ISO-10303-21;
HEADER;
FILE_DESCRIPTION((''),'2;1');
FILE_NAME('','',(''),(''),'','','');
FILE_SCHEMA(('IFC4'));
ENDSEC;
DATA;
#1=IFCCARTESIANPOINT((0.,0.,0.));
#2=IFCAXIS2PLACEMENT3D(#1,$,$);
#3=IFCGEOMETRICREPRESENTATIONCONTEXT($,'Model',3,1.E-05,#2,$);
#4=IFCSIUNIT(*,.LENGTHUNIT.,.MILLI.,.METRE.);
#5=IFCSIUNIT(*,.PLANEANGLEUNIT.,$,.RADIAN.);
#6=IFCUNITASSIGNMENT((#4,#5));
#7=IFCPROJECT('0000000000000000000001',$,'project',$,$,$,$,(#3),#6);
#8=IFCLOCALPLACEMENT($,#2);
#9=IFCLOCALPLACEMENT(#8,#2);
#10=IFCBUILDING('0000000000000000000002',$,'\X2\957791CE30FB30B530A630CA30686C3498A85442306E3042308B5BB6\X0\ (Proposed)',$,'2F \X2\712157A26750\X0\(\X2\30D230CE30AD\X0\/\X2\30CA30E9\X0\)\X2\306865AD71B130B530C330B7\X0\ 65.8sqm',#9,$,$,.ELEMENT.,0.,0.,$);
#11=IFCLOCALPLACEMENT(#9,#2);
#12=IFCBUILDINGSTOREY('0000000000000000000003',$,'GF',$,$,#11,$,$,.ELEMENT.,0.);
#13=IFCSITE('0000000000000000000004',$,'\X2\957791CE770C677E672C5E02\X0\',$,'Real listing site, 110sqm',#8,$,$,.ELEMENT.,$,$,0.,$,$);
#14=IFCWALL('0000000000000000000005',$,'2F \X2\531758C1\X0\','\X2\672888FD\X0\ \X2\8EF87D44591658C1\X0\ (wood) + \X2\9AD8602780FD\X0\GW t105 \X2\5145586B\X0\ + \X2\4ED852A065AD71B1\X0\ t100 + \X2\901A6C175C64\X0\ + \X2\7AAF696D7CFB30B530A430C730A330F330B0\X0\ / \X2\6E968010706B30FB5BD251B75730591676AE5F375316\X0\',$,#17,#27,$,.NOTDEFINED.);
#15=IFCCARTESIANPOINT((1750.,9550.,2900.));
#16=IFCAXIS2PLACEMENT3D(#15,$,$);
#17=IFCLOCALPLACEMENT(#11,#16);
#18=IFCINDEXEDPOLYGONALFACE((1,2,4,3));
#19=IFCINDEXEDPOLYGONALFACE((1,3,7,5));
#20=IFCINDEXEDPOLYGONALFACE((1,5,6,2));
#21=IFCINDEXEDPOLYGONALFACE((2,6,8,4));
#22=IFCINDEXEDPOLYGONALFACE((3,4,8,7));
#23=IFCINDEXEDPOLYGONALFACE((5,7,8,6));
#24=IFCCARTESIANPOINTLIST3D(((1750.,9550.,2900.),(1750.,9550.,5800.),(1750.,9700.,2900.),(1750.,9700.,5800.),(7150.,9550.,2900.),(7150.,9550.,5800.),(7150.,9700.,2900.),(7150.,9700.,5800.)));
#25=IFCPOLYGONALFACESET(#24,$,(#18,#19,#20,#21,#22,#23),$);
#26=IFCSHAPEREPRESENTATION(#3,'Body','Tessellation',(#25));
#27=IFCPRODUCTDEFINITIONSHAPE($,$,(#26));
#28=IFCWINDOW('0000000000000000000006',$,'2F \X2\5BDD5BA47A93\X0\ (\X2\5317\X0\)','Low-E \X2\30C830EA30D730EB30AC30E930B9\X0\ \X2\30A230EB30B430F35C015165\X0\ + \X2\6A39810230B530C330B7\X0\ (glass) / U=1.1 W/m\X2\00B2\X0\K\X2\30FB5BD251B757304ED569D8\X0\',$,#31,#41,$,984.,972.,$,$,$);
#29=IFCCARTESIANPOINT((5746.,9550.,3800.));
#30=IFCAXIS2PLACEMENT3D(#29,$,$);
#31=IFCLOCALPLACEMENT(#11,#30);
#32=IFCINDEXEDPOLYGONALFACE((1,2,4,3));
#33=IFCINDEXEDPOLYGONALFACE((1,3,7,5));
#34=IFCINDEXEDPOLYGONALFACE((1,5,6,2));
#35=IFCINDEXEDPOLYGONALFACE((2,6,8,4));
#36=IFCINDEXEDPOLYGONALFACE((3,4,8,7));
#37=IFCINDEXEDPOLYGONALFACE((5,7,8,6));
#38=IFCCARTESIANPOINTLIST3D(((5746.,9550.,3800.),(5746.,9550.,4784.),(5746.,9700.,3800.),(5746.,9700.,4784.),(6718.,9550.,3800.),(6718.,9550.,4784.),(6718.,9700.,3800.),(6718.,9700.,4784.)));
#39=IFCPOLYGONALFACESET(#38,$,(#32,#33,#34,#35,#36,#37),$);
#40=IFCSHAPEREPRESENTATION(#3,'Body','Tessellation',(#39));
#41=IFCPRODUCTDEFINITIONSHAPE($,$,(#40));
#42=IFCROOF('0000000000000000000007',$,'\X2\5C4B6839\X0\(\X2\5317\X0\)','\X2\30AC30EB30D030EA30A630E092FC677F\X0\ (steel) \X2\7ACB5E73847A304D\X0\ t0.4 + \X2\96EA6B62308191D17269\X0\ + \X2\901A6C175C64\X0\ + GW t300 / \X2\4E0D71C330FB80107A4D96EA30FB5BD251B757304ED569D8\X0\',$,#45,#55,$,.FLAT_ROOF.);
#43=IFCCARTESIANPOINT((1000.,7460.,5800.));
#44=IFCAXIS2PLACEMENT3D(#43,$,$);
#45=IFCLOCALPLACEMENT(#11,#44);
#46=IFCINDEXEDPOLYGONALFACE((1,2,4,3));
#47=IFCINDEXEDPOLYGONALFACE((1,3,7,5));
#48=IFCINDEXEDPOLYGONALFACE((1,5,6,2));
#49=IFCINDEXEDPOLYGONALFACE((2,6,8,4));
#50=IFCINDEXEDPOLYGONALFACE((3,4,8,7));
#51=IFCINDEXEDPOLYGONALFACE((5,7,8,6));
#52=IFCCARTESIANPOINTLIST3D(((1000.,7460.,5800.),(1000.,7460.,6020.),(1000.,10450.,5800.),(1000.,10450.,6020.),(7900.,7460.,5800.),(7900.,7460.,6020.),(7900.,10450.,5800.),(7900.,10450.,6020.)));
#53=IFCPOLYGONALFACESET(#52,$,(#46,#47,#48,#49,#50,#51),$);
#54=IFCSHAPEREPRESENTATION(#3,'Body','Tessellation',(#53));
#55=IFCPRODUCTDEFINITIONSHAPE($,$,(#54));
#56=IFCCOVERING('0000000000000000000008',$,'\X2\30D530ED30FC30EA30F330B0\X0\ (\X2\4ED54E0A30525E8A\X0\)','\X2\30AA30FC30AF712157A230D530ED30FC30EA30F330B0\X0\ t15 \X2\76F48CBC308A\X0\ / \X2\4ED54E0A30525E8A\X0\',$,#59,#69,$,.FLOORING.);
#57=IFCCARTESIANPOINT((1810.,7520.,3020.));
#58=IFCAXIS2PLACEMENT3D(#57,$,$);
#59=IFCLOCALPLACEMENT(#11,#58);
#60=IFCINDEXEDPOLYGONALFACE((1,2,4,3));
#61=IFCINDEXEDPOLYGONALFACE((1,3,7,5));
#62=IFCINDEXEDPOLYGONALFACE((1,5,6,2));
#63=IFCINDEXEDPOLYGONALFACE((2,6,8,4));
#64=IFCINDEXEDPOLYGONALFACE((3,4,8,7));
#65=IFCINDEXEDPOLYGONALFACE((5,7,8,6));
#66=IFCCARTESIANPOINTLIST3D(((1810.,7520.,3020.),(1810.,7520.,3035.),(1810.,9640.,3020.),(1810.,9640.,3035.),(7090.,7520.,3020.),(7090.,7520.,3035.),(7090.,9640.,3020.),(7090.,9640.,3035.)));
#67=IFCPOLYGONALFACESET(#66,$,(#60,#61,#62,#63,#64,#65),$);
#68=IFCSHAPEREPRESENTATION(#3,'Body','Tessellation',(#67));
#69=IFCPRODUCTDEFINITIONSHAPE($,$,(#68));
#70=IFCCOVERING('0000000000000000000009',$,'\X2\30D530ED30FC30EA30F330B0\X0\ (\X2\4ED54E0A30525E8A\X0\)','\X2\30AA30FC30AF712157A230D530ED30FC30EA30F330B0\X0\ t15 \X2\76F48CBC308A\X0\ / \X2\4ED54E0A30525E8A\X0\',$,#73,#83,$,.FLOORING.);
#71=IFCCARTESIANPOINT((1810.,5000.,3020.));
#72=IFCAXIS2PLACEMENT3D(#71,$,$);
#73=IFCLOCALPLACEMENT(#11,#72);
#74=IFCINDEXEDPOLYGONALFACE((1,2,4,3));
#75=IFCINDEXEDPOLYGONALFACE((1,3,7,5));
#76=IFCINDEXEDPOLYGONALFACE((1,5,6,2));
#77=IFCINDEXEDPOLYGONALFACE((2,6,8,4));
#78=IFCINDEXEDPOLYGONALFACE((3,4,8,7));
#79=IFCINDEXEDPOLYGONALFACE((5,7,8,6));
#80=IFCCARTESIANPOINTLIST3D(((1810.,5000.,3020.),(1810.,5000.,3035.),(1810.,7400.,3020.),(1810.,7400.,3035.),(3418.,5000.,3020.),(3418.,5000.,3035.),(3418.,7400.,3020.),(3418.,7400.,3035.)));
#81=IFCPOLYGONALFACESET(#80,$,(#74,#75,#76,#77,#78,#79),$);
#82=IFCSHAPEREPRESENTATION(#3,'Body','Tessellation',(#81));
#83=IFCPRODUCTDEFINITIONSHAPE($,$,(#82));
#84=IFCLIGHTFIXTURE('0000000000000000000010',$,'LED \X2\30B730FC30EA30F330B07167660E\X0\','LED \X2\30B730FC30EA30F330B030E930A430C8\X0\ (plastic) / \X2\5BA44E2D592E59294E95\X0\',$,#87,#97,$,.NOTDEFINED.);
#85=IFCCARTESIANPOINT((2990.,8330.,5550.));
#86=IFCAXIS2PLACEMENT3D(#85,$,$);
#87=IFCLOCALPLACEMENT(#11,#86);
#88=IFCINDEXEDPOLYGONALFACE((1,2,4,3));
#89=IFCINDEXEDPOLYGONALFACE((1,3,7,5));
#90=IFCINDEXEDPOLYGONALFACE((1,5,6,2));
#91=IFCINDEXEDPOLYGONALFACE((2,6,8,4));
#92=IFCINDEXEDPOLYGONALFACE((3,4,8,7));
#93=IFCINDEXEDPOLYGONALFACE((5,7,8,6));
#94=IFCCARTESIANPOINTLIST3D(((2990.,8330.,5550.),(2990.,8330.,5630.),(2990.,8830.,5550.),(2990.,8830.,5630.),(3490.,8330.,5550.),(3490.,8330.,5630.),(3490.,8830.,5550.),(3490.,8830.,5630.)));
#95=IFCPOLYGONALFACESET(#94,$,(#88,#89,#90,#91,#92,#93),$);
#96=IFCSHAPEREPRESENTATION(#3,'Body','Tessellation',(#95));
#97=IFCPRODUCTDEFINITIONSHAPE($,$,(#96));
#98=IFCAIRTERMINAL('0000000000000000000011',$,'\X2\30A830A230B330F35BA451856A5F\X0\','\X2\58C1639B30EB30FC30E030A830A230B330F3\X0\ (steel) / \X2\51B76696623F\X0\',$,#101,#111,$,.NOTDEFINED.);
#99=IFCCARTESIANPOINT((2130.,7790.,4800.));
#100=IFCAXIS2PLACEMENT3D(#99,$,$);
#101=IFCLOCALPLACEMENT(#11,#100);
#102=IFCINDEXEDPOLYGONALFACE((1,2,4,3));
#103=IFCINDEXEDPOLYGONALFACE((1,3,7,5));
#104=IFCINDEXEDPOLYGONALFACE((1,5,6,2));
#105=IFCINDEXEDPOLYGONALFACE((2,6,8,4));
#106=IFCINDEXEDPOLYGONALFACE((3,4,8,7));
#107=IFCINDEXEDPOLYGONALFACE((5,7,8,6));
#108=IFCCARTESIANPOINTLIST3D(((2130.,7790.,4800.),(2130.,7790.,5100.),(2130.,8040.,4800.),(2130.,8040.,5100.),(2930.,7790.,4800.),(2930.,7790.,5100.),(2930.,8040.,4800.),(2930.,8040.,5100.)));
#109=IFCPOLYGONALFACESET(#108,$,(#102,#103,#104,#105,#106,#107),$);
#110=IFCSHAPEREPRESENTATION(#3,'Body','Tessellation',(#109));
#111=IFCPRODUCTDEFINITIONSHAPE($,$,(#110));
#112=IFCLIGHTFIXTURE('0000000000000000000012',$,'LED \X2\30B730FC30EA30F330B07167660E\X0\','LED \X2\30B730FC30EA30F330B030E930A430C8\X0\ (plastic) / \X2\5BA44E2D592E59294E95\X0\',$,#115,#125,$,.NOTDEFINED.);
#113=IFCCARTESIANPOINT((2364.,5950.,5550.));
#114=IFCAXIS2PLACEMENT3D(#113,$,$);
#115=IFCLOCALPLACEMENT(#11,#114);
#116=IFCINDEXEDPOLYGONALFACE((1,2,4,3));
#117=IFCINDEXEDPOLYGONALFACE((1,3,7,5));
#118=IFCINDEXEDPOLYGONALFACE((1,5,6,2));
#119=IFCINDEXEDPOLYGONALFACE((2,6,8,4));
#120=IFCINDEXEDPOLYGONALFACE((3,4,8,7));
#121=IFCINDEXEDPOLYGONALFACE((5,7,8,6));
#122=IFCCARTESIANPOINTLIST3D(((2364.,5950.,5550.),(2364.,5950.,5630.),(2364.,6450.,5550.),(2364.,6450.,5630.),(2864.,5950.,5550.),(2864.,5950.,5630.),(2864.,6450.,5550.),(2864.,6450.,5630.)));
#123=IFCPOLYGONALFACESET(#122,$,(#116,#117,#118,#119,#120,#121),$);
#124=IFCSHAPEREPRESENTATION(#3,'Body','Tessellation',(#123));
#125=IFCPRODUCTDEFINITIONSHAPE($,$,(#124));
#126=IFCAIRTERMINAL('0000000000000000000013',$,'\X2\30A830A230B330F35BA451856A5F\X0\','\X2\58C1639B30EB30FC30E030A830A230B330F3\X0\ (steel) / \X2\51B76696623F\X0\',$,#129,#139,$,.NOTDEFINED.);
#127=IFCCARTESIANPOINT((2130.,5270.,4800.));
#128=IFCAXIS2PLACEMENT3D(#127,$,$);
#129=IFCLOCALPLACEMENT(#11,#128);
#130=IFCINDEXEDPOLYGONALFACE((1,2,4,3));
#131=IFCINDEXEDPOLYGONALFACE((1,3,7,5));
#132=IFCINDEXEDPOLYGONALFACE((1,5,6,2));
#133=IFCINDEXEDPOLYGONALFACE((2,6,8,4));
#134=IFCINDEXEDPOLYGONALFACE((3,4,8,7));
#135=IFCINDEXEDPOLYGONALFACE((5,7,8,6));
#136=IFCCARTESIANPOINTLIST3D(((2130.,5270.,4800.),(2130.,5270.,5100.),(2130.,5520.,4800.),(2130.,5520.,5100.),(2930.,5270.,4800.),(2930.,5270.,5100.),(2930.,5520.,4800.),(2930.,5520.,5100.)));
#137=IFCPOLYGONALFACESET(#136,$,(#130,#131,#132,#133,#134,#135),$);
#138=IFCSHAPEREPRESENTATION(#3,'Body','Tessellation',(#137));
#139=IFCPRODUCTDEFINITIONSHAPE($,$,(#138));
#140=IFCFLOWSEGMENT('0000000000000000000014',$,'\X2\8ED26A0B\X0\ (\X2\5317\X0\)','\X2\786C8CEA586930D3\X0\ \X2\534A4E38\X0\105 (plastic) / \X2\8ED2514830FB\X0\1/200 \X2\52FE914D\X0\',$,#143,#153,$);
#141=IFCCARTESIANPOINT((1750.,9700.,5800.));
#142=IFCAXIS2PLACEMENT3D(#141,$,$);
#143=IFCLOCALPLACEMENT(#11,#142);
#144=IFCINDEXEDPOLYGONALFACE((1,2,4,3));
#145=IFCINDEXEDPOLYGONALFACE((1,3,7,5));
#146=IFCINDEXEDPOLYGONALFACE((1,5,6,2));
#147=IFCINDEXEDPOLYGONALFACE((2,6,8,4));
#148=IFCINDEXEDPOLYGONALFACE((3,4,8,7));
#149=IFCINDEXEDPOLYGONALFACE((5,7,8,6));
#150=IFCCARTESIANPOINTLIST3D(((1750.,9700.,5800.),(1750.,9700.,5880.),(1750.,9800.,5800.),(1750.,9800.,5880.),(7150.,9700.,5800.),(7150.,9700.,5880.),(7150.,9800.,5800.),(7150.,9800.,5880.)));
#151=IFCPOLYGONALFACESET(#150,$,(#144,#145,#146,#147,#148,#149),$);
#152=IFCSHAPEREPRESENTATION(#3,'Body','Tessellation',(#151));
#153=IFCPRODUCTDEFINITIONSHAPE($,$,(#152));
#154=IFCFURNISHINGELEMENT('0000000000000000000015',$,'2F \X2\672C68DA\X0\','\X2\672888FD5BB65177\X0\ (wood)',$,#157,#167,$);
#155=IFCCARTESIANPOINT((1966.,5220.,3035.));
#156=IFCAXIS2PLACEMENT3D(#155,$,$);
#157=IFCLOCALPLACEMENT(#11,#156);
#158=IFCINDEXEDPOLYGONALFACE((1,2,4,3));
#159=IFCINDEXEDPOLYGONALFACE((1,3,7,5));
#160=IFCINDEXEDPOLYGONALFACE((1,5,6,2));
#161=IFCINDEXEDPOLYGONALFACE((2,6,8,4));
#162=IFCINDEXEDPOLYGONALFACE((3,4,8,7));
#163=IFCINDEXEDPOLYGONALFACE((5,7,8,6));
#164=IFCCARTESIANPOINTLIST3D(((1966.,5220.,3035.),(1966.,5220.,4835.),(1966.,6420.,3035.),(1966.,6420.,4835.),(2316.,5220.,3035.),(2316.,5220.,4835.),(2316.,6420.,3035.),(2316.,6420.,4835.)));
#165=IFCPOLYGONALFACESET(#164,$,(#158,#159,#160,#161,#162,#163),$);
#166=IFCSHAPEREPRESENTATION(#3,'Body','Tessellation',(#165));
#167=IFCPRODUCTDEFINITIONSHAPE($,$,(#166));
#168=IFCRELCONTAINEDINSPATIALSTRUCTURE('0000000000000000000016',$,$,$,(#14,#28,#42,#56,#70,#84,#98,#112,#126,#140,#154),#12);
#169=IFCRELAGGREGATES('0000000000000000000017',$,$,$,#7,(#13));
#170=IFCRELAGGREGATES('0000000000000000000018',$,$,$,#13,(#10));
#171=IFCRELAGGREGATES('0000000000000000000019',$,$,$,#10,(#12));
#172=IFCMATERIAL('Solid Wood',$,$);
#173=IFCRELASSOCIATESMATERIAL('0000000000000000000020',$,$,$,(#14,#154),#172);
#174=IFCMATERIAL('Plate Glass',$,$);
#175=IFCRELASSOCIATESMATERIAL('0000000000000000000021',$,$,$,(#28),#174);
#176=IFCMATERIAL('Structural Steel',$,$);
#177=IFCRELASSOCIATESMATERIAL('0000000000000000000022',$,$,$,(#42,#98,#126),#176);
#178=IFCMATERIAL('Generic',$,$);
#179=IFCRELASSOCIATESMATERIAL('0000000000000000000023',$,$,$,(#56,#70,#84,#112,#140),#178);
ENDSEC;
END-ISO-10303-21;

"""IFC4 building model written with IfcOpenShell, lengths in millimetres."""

from ifc_helpers import new_model, si_unit, frame, frame_2d, origin, place, context, project, spatial, rectangle, extrude, material, element, fill, save


model = new_model("IFC4")

# Units and contexts
model_context = context("Model", 3, precision=1e-05, world=origin())
ifc_project = project(units=[si_unit("LENGTHUNIT", "METRE", prefix="MILLI"), si_unit("PLANEANGLEUNIT", "RADIAN")], contexts=[model_context])

# Site, building, storey
site_placement = place(None, origin())
site = spatial("IfcSite", under=ifc_project, at=site_placement, Name="長野県松本市", ObjectType="Real listing site, 110sqm", CompositionType="ELEMENT", RefElevation=0.0)
building_placement = place(site_placement, origin())
building = spatial("IfcBuilding", under=site, at=building_placement, Name="長野・サウナと水風呂のある家 (Proposed)", ObjectType="2F 無垢材(ヒノキ/ナラ)と断熱サッシ 65.8sqm", CompositionType="ELEMENT", ElevationOfRefHeight=0.0, ElevationOfTerrain=0.0)
storey_placement = place(building_placement, origin())
storey = spatial("IfcBuildingStorey", under=building, at=storey_placement, Name="GF", CompositionType="ELEMENT", Elevation=0.0)

# Shared definitions
ifc_material_1 = material(Name="Solid Wood")

# Wall, opening, window
wall_placement = place(storey_placement, frame((1750.0, 9550.0, 2900.0)))
wall = element("IfcWall", 1, at=wall_placement, inside=storey, material=ifc_material_1, Name="2F 北壁", Description="木製 軸組外壁 (wood) + 高性能GW t105 充填 + 付加断熱 t100 + 通気層 + 窯業系サイディング / 準耐火・寒冷地外皮強化", PredefinedType="NOTDEFINED", context=model_context, shape_type="SweptSolid", body=[
    extrude(rectangle(XDim=5400.0, YDim=150.0, at=frame_2d((2700.0, 75.0))), frame((1750.0, 9550.0, 2900.0)), (0.0, 0.0, 1.0), 2900.0),
])
opening_placement = place(storey_placement, frame((5746.0, 9550.0, 3800.0)))
opening = element("IfcOpeningElement", 2, at=opening_placement, cuts=wall, PredefinedType="NOTDEFINED", context=model_context, shape_type="SweptSolid", body=[
    extrude(rectangle(XDim=972.0, YDim=150.0, at=frame_2d((486.0, 75.0))), frame((5746.0, 9550.0, 3800.0)), (0.0, 0.0, 1.0), 984.0),
])
ifc_material_2 = material(Name="Plate Glass")
window_placement = place(storey_placement, frame((5746.0, 9550.0, 3800.0)))
window = element("IfcWindow", 3, at=window_placement, inside=storey, material=ifc_material_2, Name="2F 寝室窓 (北)", Description="Low-E トリプルガラス アルゴン封入 + 樹脂サッシ (glass) / U=1.1 W/m²K・寒冷地仕様", OverallHeight=984.0, OverallWidth=972.0, context=model_context, shape_type="SweptSolid", body=[
    extrude(rectangle(XDim=972.0, YDim=150.0, at=frame_2d((486.0, 75.0))), frame((5746.0, 9550.0, 3800.0)), (0.0, 0.0, 1.0), 984.0),
])
fill(opening, window)

# Roof
ifc_material_3 = material(Name="Structural Steel")
for number, where, name in (
    (4, (1000.0, 7460.0, 5800.0), "屋根(北)"),
):
    element("IfcRoof", number, at=place(storey_placement, frame(where)), inside=storey, material=ifc_material_3, Name=name, Description="ガルバリウム鋼板 (steel) 立平葺き t0.4 + 雪止め金物 + 通気層 + GW t300 / 不燃・耐積雪・寒冷地仕様", PredefinedType="FLAT_ROOF", context=model_context, shape_type="SweptSolid", body=[
        extrude(rectangle(XDim=6900.0, YDim=2990.0, at=frame_2d((3450.0, 1495.0))), frame((1000.0, 7460.0, 5800.0)), (0.0, 0.0, 1.0), 220.0),
    ])

# Coverings
ifc_material_4 = material(Name="Generic")
covering_1_placement = place(storey_placement, frame((1810.0, 7520.0, 3020.0)))
element("IfcCovering", 5, at=covering_1_placement, inside=storey, material=ifc_material_4, Name="フローリング (仕上げ床)", Description="オーク無垢フローリング t15 直貼り / 仕上げ床", PredefinedType="FLOORING", context=model_context, shape_type="SweptSolid", body=[
    extrude(rectangle(XDim=5280.0, YDim=2120.0, at=frame_2d((2640.0, 1060.0))), frame((1810.0, 7520.0, 3020.0)), (0.0, 0.0, 1.0), 15.0),
])
covering_2_placement = place(storey_placement, frame((1810.0, 5000.0, 3020.0)))
element("IfcCovering", 6, at=covering_2_placement, inside=storey, material=ifc_material_4, Name="フローリング (仕上げ床)", Description="オーク無垢フローリング t15 直貼り / 仕上げ床", PredefinedType="FLOORING", context=model_context, shape_type="SweptSolid", body=[
    extrude(rectangle(XDim=1608.0, YDim=2400.0, at=frame_2d((804.0, 1200.0))), frame((1810.0, 5000.0, 3020.0)), (0.0, 0.0, 1.0), 15.0),
])

# Light fixture
light_fixture_1_placement = place(storey_placement, frame((2990.0, 8330.0, 5550.0)))
element("IfcLightFixture", 7, at=light_fixture_1_placement, inside=storey, material=ifc_material_4, Name="LED シーリング照明", Description="LED シーリングライト (plastic) / 室中央天井", PredefinedType="NOTDEFINED", context=model_context, shape_type="SweptSolid", body=[
    extrude(rectangle(XDim=500.0, YDim=500.0, at=frame_2d((250.0, 250.0))), frame((2990.0, 8330.0, 5550.0)), (0.0, 0.0, 1.0), 80.0),
])

# Air terminal
air_terminal_1_placement = place(storey_placement, frame((2130.0, 7790.0, 4800.0)))
element("IfcAirTerminal", 8, at=air_terminal_1_placement, inside=storey, material=ifc_material_3, Name="エアコン室内機", Description="壁掛ルームエアコン (steel) / 冷暖房", PredefinedType="NOTDEFINED", context=model_context, shape_type="SweptSolid", body=[
    extrude(rectangle(XDim=800.0, YDim=250.0, at=frame_2d((400.0, 125.0))), frame((2130.0, 7790.0, 4800.0)), (0.0, 0.0, 1.0), 300.0),
])

# Light fixture
light_fixture_2_placement = place(storey_placement, frame((2364.0, 5950.0, 5550.0)))
element("IfcLightFixture", 9, at=light_fixture_2_placement, inside=storey, material=ifc_material_4, Name="LED シーリング照明", Description="LED シーリングライト (plastic) / 室中央天井", PredefinedType="NOTDEFINED", context=model_context, shape_type="SweptSolid", body=[
    extrude(rectangle(XDim=500.0, YDim=500.0, at=frame_2d((250.0, 250.0))), frame((2364.0, 5950.0, 5550.0)), (0.0, 0.0, 1.0), 80.0),
])

# Air terminal
air_terminal_2_placement = place(storey_placement, frame((2130.0, 5270.0, 4800.0)))
element("IfcAirTerminal", 10, at=air_terminal_2_placement, inside=storey, material=ifc_material_3, Name="エアコン室内機", Description="壁掛ルームエアコン (steel) / 冷暖房", PredefinedType="NOTDEFINED", context=model_context, shape_type="SweptSolid", body=[
    extrude(rectangle(XDim=800.0, YDim=250.0, at=frame_2d((400.0, 125.0))), frame((2130.0, 5270.0, 4800.0)), (0.0, 0.0, 1.0), 300.0),
])

# Flow segment
flow_segment_placement = place(storey_placement, frame((1750.0, 9700.0, 5800.0)))
element("IfcFlowSegment", 11, at=flow_segment_placement, inside=storey, material=ifc_material_4, Name="軒樋 (北)", Description="硬質塩ビ 半丸105 (plastic) / 軒先・1/200 勾配", context=model_context, shape_type="SweptSolid", body=[
    extrude(rectangle(XDim=5400.0, YDim=100.0, at=frame_2d((2700.0, 50.0))), frame((1750.0, 9700.0, 5800.0)), (0.0, 0.0, 1.0), 80.0),
])

# Furnishing element
furnishing_placement = place(storey_placement, frame((1966.0, 5220.0, 3035.0)))
element("IfcFurnishingElement", 12, at=furnishing_placement, inside=storey, material=ifc_material_1, Name="2F 本棚", Description="木製家具 (wood)", context=model_context, shape_type="SweptSolid", body=[
    extrude(rectangle(XDim=350.0, YDim=1200.0, at=frame_2d((175.0, 600.0))), frame((1966.0, 5220.0, 3035.0)), (0.0, 0.0, 1.0), 1800.0),
])

save(model, "model.ifc")
